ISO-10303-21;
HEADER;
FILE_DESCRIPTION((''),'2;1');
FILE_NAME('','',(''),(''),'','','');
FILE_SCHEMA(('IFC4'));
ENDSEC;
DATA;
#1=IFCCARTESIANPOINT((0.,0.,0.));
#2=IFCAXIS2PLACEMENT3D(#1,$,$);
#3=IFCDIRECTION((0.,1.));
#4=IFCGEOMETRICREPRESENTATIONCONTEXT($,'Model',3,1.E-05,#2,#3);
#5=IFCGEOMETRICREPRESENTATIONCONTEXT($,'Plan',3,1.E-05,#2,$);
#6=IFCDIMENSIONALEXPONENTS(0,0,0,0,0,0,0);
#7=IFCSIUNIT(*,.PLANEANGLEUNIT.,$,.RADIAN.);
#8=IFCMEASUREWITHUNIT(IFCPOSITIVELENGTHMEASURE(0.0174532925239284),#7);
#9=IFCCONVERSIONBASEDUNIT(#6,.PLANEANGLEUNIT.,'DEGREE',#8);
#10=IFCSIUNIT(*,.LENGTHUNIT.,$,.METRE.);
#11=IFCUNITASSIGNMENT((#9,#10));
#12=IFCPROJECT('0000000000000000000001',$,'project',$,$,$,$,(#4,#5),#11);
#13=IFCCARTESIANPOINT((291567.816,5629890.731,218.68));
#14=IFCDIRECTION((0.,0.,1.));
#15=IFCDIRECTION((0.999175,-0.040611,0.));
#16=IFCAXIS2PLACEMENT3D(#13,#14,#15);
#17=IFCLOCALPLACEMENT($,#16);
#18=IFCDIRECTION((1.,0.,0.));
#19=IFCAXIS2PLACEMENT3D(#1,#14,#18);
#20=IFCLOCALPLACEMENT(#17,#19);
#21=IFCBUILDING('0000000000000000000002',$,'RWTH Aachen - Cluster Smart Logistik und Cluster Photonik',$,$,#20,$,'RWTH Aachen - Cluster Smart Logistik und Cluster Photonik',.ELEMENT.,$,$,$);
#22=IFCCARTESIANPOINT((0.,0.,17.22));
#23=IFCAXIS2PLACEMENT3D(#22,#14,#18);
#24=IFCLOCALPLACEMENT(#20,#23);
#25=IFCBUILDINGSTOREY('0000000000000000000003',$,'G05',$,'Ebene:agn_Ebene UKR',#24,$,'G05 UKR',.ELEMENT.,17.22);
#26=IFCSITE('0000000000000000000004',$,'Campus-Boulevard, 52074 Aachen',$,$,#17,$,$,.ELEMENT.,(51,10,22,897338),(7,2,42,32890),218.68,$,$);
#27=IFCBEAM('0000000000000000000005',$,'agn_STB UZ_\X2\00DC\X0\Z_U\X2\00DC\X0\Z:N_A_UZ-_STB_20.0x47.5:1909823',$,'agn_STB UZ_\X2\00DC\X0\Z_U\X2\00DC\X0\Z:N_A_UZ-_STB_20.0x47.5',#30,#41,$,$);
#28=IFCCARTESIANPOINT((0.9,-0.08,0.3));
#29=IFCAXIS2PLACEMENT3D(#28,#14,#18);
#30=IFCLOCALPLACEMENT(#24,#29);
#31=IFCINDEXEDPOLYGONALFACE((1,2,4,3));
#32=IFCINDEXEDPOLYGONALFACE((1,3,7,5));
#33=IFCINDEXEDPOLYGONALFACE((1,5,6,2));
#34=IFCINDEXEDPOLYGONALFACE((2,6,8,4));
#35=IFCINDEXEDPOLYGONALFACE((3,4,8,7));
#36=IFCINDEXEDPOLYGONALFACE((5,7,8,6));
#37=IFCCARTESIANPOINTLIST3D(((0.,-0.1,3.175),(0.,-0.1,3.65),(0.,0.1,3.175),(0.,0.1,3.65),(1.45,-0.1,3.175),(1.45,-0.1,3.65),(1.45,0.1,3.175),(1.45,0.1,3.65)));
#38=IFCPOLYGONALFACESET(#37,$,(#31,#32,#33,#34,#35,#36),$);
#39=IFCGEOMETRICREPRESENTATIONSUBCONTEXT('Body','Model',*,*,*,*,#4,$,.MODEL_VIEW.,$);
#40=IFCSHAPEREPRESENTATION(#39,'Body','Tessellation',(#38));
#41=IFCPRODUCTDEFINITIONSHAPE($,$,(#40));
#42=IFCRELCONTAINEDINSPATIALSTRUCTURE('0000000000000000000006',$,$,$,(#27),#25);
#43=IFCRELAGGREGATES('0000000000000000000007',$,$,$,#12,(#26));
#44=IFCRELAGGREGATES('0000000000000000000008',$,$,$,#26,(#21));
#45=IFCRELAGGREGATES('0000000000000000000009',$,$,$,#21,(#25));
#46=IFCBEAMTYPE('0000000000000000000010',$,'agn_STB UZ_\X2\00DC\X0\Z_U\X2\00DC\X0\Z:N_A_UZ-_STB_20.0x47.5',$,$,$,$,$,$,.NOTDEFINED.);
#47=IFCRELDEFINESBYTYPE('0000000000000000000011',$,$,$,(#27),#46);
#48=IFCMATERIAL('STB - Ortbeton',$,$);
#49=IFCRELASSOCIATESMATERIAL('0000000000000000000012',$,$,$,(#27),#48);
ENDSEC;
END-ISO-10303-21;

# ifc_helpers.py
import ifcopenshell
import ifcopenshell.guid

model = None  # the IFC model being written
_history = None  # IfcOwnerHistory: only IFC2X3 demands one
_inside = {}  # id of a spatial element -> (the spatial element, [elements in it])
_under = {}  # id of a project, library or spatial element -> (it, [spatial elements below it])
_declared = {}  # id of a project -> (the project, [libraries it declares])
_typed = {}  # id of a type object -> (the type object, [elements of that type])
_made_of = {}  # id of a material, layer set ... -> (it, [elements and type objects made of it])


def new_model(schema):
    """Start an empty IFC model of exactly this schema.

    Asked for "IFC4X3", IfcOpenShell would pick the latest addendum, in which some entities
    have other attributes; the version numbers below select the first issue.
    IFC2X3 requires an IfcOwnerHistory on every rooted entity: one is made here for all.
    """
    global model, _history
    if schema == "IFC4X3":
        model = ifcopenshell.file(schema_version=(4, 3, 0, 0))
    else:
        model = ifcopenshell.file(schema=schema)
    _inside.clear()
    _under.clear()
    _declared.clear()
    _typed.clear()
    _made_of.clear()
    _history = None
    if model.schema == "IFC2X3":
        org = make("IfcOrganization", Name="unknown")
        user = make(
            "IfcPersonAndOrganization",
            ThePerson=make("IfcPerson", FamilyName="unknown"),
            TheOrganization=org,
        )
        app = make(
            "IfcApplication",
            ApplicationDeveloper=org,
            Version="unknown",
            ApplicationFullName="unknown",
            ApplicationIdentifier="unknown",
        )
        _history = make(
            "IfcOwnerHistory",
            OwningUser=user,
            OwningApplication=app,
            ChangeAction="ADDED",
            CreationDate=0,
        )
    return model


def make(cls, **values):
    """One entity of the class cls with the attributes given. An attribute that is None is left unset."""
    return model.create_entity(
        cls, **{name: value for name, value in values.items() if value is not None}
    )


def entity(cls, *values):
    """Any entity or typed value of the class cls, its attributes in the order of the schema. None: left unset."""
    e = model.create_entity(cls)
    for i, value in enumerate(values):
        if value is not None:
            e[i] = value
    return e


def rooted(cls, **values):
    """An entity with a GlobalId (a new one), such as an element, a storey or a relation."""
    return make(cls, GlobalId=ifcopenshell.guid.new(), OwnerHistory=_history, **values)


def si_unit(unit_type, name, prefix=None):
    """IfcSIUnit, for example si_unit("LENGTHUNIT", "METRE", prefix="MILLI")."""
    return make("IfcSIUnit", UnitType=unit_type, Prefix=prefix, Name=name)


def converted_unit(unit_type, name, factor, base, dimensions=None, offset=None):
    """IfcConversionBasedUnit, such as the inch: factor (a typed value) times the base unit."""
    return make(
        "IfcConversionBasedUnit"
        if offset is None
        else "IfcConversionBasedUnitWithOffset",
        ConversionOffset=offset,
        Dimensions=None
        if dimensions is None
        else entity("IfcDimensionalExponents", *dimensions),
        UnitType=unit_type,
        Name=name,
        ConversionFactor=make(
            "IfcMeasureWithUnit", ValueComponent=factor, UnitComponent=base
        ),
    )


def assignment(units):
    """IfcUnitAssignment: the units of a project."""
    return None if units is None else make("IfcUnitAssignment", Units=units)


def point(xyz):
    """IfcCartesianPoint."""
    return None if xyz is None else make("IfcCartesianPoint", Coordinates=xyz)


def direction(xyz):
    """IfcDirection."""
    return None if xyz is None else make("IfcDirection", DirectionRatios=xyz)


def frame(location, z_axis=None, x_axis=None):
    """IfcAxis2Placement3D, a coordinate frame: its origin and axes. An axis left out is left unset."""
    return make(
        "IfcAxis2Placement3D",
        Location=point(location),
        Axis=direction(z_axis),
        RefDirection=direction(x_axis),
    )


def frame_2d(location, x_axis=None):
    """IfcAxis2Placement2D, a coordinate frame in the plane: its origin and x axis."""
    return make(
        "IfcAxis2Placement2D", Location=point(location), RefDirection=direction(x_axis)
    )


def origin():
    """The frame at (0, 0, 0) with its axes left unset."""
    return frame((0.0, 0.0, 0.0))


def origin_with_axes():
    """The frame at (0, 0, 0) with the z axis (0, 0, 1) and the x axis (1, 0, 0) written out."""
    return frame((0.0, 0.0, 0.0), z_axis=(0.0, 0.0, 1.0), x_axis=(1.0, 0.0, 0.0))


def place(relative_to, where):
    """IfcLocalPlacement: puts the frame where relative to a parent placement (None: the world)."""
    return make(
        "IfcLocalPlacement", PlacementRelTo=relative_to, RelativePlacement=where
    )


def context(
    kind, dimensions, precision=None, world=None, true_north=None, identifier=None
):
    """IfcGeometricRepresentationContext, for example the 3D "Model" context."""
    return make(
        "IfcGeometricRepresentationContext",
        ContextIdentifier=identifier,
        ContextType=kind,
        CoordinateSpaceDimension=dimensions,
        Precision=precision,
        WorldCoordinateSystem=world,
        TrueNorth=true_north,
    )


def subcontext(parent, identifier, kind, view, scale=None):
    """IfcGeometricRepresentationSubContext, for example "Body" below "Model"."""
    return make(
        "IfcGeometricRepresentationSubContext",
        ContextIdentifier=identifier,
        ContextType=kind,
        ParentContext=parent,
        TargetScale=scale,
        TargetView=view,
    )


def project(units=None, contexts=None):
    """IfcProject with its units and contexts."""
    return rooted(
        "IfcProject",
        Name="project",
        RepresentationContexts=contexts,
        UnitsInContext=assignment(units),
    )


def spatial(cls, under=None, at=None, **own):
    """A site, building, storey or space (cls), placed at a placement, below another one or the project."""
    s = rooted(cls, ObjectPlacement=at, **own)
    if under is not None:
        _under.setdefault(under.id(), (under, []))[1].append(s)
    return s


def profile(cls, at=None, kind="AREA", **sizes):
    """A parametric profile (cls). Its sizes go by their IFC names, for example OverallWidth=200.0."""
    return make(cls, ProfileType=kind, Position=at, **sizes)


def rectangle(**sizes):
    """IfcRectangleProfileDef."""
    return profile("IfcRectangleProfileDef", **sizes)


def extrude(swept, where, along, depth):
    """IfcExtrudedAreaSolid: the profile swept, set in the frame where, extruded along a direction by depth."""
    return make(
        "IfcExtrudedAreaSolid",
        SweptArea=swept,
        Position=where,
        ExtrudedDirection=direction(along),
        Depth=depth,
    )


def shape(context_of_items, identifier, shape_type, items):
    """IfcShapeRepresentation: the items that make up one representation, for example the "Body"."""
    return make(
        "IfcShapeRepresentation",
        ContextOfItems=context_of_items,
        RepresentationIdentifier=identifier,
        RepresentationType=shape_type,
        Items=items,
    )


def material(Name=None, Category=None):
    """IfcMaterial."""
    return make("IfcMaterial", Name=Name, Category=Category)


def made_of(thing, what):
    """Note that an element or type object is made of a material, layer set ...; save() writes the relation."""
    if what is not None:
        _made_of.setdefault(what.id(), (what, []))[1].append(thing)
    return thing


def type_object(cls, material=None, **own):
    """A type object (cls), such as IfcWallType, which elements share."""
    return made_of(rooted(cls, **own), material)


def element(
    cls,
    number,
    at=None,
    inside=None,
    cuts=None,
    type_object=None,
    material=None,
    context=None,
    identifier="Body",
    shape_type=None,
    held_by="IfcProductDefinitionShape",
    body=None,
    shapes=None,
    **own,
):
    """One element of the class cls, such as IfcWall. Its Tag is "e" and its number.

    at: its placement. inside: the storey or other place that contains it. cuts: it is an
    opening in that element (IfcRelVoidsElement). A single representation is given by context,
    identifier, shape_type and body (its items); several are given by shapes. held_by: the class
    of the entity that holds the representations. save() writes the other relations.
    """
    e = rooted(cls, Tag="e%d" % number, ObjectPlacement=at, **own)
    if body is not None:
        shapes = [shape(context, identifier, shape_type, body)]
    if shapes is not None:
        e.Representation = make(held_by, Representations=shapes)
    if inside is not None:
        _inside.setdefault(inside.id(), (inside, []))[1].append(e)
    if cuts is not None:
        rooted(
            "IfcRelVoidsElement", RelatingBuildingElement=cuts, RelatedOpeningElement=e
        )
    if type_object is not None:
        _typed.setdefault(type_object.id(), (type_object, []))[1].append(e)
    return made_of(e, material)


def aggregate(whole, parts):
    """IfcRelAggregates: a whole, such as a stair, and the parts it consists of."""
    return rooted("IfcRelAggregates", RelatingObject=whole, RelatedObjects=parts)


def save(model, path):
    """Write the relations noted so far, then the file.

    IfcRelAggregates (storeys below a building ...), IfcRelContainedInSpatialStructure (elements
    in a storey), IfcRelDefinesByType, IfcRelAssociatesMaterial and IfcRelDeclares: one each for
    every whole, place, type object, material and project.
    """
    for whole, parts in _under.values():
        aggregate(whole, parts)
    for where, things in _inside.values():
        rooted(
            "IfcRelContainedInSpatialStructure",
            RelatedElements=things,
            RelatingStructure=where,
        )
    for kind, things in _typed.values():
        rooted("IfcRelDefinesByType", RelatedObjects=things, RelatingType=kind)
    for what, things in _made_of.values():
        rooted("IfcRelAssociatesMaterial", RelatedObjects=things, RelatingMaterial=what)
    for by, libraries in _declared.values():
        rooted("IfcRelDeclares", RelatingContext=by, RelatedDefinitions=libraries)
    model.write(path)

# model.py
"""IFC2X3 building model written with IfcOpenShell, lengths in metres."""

from ifc_helpers import new_model, entity, si_unit, converted_unit, direction, frame, frame_2d, origin, origin_with_axes, place, context, subcontext, project, spatial, rectangle, extrude, material, type_object, element, save


model = new_model("IFC2X3")

# Units and contexts
model_context = context("Model", 3, precision=1e-05, world=origin(), true_north=direction((0.0, 1.0)))
plan_context = context("Plan", 3, precision=1e-05, world=origin())
body_context = subcontext(model_context, "Body", "Model", "MODEL_VIEW")
ifc_project = project(units=[converted_unit("PLANEANGLEUNIT", "DEGREE", entity("IfcPositiveLengthMeasure", 0.0174532925239284), si_unit("PLANEANGLEUNIT", "RADIAN"), dimensions=[0, 0, 0, 0, 0, 0, 0]), si_unit("LENGTHUNIT", "METRE")], contexts=[model_context, plan_context])

# Site, building, storey
site_placement = place(None, frame((291567.816, 5629890.731, 218.68), z_axis=(0.0, 0.0, 1.0), x_axis=(0.999175, -0.040611, 0.0)))
site = spatial("IfcSite", under=ifc_project, at=site_placement, Name="Campus-Boulevard, 52074 Aachen", CompositionType="ELEMENT", RefLatitude=(51, 10, 22, 897338), RefLongitude=(7, 2, 42, 32890), RefElevation=218.68)
building_placement = place(site_placement, origin_with_axes())
building = spatial("IfcBuilding", under=site, at=building_placement, Name="RWTH Aachen - Cluster Smart Logistik und Cluster Photonik", LongName="RWTH Aachen - Cluster Smart Logistik und Cluster Photonik", CompositionType="ELEMENT")
storey_placement = place(building_placement, frame((0.0, 0.0, 17.22), z_axis=(0.0, 0.0, 1.0), x_axis=(1.0, 0.0, 0.0)))
storey = spatial("IfcBuildingStorey", under=building, at=storey_placement, Name="G05", ObjectType="Ebene:agn_Ebene UKR", LongName="G05 UKR", CompositionType="ELEMENT", Elevation=17.22)

# Shared definitions
ifc_material_1 = material(Name="STB - Ortbeton")

# Beam
beam_type_1 = type_object("IfcBeamType", Name="agn_STB UZ_ÜZ_UÜZ:N_A_UZ-_STB_20.0x47.5", PredefinedType="NOTDEFINED")
beam_1_placement = place(storey_placement, frame((0.9, -0.08, 0.3), z_axis=(0.0, 0.0, 1.0), x_axis=(1.0, 0.0, 0.0)))
element("IfcBeam", 1, at=beam_1_placement, inside=storey, type_object=beam_type_1, material=ifc_material_1, Name="agn_STB UZ_ÜZ_UÜZ:N_A_UZ-_STB_20.0x47.5:1909823", ObjectType="agn_STB UZ_ÜZ_UÜZ:N_A_UZ-_STB_20.0x47.5", context=body_context, shape_type="SweptSolid", body=[
    extrude(rectangle(XDim=0.475, YDim=0.2, at=frame_2d((0.0, 0.0), x_axis=(1.0, 0.0))), frame((0.0, 0.0, 3.4125), z_axis=(1.0, 0.0, 0.0), x_axis=(0.0, 0.0, -1.0)), (0.0, 0.0, 1.0), 1.45),
])

save(model, "model.ifc")
